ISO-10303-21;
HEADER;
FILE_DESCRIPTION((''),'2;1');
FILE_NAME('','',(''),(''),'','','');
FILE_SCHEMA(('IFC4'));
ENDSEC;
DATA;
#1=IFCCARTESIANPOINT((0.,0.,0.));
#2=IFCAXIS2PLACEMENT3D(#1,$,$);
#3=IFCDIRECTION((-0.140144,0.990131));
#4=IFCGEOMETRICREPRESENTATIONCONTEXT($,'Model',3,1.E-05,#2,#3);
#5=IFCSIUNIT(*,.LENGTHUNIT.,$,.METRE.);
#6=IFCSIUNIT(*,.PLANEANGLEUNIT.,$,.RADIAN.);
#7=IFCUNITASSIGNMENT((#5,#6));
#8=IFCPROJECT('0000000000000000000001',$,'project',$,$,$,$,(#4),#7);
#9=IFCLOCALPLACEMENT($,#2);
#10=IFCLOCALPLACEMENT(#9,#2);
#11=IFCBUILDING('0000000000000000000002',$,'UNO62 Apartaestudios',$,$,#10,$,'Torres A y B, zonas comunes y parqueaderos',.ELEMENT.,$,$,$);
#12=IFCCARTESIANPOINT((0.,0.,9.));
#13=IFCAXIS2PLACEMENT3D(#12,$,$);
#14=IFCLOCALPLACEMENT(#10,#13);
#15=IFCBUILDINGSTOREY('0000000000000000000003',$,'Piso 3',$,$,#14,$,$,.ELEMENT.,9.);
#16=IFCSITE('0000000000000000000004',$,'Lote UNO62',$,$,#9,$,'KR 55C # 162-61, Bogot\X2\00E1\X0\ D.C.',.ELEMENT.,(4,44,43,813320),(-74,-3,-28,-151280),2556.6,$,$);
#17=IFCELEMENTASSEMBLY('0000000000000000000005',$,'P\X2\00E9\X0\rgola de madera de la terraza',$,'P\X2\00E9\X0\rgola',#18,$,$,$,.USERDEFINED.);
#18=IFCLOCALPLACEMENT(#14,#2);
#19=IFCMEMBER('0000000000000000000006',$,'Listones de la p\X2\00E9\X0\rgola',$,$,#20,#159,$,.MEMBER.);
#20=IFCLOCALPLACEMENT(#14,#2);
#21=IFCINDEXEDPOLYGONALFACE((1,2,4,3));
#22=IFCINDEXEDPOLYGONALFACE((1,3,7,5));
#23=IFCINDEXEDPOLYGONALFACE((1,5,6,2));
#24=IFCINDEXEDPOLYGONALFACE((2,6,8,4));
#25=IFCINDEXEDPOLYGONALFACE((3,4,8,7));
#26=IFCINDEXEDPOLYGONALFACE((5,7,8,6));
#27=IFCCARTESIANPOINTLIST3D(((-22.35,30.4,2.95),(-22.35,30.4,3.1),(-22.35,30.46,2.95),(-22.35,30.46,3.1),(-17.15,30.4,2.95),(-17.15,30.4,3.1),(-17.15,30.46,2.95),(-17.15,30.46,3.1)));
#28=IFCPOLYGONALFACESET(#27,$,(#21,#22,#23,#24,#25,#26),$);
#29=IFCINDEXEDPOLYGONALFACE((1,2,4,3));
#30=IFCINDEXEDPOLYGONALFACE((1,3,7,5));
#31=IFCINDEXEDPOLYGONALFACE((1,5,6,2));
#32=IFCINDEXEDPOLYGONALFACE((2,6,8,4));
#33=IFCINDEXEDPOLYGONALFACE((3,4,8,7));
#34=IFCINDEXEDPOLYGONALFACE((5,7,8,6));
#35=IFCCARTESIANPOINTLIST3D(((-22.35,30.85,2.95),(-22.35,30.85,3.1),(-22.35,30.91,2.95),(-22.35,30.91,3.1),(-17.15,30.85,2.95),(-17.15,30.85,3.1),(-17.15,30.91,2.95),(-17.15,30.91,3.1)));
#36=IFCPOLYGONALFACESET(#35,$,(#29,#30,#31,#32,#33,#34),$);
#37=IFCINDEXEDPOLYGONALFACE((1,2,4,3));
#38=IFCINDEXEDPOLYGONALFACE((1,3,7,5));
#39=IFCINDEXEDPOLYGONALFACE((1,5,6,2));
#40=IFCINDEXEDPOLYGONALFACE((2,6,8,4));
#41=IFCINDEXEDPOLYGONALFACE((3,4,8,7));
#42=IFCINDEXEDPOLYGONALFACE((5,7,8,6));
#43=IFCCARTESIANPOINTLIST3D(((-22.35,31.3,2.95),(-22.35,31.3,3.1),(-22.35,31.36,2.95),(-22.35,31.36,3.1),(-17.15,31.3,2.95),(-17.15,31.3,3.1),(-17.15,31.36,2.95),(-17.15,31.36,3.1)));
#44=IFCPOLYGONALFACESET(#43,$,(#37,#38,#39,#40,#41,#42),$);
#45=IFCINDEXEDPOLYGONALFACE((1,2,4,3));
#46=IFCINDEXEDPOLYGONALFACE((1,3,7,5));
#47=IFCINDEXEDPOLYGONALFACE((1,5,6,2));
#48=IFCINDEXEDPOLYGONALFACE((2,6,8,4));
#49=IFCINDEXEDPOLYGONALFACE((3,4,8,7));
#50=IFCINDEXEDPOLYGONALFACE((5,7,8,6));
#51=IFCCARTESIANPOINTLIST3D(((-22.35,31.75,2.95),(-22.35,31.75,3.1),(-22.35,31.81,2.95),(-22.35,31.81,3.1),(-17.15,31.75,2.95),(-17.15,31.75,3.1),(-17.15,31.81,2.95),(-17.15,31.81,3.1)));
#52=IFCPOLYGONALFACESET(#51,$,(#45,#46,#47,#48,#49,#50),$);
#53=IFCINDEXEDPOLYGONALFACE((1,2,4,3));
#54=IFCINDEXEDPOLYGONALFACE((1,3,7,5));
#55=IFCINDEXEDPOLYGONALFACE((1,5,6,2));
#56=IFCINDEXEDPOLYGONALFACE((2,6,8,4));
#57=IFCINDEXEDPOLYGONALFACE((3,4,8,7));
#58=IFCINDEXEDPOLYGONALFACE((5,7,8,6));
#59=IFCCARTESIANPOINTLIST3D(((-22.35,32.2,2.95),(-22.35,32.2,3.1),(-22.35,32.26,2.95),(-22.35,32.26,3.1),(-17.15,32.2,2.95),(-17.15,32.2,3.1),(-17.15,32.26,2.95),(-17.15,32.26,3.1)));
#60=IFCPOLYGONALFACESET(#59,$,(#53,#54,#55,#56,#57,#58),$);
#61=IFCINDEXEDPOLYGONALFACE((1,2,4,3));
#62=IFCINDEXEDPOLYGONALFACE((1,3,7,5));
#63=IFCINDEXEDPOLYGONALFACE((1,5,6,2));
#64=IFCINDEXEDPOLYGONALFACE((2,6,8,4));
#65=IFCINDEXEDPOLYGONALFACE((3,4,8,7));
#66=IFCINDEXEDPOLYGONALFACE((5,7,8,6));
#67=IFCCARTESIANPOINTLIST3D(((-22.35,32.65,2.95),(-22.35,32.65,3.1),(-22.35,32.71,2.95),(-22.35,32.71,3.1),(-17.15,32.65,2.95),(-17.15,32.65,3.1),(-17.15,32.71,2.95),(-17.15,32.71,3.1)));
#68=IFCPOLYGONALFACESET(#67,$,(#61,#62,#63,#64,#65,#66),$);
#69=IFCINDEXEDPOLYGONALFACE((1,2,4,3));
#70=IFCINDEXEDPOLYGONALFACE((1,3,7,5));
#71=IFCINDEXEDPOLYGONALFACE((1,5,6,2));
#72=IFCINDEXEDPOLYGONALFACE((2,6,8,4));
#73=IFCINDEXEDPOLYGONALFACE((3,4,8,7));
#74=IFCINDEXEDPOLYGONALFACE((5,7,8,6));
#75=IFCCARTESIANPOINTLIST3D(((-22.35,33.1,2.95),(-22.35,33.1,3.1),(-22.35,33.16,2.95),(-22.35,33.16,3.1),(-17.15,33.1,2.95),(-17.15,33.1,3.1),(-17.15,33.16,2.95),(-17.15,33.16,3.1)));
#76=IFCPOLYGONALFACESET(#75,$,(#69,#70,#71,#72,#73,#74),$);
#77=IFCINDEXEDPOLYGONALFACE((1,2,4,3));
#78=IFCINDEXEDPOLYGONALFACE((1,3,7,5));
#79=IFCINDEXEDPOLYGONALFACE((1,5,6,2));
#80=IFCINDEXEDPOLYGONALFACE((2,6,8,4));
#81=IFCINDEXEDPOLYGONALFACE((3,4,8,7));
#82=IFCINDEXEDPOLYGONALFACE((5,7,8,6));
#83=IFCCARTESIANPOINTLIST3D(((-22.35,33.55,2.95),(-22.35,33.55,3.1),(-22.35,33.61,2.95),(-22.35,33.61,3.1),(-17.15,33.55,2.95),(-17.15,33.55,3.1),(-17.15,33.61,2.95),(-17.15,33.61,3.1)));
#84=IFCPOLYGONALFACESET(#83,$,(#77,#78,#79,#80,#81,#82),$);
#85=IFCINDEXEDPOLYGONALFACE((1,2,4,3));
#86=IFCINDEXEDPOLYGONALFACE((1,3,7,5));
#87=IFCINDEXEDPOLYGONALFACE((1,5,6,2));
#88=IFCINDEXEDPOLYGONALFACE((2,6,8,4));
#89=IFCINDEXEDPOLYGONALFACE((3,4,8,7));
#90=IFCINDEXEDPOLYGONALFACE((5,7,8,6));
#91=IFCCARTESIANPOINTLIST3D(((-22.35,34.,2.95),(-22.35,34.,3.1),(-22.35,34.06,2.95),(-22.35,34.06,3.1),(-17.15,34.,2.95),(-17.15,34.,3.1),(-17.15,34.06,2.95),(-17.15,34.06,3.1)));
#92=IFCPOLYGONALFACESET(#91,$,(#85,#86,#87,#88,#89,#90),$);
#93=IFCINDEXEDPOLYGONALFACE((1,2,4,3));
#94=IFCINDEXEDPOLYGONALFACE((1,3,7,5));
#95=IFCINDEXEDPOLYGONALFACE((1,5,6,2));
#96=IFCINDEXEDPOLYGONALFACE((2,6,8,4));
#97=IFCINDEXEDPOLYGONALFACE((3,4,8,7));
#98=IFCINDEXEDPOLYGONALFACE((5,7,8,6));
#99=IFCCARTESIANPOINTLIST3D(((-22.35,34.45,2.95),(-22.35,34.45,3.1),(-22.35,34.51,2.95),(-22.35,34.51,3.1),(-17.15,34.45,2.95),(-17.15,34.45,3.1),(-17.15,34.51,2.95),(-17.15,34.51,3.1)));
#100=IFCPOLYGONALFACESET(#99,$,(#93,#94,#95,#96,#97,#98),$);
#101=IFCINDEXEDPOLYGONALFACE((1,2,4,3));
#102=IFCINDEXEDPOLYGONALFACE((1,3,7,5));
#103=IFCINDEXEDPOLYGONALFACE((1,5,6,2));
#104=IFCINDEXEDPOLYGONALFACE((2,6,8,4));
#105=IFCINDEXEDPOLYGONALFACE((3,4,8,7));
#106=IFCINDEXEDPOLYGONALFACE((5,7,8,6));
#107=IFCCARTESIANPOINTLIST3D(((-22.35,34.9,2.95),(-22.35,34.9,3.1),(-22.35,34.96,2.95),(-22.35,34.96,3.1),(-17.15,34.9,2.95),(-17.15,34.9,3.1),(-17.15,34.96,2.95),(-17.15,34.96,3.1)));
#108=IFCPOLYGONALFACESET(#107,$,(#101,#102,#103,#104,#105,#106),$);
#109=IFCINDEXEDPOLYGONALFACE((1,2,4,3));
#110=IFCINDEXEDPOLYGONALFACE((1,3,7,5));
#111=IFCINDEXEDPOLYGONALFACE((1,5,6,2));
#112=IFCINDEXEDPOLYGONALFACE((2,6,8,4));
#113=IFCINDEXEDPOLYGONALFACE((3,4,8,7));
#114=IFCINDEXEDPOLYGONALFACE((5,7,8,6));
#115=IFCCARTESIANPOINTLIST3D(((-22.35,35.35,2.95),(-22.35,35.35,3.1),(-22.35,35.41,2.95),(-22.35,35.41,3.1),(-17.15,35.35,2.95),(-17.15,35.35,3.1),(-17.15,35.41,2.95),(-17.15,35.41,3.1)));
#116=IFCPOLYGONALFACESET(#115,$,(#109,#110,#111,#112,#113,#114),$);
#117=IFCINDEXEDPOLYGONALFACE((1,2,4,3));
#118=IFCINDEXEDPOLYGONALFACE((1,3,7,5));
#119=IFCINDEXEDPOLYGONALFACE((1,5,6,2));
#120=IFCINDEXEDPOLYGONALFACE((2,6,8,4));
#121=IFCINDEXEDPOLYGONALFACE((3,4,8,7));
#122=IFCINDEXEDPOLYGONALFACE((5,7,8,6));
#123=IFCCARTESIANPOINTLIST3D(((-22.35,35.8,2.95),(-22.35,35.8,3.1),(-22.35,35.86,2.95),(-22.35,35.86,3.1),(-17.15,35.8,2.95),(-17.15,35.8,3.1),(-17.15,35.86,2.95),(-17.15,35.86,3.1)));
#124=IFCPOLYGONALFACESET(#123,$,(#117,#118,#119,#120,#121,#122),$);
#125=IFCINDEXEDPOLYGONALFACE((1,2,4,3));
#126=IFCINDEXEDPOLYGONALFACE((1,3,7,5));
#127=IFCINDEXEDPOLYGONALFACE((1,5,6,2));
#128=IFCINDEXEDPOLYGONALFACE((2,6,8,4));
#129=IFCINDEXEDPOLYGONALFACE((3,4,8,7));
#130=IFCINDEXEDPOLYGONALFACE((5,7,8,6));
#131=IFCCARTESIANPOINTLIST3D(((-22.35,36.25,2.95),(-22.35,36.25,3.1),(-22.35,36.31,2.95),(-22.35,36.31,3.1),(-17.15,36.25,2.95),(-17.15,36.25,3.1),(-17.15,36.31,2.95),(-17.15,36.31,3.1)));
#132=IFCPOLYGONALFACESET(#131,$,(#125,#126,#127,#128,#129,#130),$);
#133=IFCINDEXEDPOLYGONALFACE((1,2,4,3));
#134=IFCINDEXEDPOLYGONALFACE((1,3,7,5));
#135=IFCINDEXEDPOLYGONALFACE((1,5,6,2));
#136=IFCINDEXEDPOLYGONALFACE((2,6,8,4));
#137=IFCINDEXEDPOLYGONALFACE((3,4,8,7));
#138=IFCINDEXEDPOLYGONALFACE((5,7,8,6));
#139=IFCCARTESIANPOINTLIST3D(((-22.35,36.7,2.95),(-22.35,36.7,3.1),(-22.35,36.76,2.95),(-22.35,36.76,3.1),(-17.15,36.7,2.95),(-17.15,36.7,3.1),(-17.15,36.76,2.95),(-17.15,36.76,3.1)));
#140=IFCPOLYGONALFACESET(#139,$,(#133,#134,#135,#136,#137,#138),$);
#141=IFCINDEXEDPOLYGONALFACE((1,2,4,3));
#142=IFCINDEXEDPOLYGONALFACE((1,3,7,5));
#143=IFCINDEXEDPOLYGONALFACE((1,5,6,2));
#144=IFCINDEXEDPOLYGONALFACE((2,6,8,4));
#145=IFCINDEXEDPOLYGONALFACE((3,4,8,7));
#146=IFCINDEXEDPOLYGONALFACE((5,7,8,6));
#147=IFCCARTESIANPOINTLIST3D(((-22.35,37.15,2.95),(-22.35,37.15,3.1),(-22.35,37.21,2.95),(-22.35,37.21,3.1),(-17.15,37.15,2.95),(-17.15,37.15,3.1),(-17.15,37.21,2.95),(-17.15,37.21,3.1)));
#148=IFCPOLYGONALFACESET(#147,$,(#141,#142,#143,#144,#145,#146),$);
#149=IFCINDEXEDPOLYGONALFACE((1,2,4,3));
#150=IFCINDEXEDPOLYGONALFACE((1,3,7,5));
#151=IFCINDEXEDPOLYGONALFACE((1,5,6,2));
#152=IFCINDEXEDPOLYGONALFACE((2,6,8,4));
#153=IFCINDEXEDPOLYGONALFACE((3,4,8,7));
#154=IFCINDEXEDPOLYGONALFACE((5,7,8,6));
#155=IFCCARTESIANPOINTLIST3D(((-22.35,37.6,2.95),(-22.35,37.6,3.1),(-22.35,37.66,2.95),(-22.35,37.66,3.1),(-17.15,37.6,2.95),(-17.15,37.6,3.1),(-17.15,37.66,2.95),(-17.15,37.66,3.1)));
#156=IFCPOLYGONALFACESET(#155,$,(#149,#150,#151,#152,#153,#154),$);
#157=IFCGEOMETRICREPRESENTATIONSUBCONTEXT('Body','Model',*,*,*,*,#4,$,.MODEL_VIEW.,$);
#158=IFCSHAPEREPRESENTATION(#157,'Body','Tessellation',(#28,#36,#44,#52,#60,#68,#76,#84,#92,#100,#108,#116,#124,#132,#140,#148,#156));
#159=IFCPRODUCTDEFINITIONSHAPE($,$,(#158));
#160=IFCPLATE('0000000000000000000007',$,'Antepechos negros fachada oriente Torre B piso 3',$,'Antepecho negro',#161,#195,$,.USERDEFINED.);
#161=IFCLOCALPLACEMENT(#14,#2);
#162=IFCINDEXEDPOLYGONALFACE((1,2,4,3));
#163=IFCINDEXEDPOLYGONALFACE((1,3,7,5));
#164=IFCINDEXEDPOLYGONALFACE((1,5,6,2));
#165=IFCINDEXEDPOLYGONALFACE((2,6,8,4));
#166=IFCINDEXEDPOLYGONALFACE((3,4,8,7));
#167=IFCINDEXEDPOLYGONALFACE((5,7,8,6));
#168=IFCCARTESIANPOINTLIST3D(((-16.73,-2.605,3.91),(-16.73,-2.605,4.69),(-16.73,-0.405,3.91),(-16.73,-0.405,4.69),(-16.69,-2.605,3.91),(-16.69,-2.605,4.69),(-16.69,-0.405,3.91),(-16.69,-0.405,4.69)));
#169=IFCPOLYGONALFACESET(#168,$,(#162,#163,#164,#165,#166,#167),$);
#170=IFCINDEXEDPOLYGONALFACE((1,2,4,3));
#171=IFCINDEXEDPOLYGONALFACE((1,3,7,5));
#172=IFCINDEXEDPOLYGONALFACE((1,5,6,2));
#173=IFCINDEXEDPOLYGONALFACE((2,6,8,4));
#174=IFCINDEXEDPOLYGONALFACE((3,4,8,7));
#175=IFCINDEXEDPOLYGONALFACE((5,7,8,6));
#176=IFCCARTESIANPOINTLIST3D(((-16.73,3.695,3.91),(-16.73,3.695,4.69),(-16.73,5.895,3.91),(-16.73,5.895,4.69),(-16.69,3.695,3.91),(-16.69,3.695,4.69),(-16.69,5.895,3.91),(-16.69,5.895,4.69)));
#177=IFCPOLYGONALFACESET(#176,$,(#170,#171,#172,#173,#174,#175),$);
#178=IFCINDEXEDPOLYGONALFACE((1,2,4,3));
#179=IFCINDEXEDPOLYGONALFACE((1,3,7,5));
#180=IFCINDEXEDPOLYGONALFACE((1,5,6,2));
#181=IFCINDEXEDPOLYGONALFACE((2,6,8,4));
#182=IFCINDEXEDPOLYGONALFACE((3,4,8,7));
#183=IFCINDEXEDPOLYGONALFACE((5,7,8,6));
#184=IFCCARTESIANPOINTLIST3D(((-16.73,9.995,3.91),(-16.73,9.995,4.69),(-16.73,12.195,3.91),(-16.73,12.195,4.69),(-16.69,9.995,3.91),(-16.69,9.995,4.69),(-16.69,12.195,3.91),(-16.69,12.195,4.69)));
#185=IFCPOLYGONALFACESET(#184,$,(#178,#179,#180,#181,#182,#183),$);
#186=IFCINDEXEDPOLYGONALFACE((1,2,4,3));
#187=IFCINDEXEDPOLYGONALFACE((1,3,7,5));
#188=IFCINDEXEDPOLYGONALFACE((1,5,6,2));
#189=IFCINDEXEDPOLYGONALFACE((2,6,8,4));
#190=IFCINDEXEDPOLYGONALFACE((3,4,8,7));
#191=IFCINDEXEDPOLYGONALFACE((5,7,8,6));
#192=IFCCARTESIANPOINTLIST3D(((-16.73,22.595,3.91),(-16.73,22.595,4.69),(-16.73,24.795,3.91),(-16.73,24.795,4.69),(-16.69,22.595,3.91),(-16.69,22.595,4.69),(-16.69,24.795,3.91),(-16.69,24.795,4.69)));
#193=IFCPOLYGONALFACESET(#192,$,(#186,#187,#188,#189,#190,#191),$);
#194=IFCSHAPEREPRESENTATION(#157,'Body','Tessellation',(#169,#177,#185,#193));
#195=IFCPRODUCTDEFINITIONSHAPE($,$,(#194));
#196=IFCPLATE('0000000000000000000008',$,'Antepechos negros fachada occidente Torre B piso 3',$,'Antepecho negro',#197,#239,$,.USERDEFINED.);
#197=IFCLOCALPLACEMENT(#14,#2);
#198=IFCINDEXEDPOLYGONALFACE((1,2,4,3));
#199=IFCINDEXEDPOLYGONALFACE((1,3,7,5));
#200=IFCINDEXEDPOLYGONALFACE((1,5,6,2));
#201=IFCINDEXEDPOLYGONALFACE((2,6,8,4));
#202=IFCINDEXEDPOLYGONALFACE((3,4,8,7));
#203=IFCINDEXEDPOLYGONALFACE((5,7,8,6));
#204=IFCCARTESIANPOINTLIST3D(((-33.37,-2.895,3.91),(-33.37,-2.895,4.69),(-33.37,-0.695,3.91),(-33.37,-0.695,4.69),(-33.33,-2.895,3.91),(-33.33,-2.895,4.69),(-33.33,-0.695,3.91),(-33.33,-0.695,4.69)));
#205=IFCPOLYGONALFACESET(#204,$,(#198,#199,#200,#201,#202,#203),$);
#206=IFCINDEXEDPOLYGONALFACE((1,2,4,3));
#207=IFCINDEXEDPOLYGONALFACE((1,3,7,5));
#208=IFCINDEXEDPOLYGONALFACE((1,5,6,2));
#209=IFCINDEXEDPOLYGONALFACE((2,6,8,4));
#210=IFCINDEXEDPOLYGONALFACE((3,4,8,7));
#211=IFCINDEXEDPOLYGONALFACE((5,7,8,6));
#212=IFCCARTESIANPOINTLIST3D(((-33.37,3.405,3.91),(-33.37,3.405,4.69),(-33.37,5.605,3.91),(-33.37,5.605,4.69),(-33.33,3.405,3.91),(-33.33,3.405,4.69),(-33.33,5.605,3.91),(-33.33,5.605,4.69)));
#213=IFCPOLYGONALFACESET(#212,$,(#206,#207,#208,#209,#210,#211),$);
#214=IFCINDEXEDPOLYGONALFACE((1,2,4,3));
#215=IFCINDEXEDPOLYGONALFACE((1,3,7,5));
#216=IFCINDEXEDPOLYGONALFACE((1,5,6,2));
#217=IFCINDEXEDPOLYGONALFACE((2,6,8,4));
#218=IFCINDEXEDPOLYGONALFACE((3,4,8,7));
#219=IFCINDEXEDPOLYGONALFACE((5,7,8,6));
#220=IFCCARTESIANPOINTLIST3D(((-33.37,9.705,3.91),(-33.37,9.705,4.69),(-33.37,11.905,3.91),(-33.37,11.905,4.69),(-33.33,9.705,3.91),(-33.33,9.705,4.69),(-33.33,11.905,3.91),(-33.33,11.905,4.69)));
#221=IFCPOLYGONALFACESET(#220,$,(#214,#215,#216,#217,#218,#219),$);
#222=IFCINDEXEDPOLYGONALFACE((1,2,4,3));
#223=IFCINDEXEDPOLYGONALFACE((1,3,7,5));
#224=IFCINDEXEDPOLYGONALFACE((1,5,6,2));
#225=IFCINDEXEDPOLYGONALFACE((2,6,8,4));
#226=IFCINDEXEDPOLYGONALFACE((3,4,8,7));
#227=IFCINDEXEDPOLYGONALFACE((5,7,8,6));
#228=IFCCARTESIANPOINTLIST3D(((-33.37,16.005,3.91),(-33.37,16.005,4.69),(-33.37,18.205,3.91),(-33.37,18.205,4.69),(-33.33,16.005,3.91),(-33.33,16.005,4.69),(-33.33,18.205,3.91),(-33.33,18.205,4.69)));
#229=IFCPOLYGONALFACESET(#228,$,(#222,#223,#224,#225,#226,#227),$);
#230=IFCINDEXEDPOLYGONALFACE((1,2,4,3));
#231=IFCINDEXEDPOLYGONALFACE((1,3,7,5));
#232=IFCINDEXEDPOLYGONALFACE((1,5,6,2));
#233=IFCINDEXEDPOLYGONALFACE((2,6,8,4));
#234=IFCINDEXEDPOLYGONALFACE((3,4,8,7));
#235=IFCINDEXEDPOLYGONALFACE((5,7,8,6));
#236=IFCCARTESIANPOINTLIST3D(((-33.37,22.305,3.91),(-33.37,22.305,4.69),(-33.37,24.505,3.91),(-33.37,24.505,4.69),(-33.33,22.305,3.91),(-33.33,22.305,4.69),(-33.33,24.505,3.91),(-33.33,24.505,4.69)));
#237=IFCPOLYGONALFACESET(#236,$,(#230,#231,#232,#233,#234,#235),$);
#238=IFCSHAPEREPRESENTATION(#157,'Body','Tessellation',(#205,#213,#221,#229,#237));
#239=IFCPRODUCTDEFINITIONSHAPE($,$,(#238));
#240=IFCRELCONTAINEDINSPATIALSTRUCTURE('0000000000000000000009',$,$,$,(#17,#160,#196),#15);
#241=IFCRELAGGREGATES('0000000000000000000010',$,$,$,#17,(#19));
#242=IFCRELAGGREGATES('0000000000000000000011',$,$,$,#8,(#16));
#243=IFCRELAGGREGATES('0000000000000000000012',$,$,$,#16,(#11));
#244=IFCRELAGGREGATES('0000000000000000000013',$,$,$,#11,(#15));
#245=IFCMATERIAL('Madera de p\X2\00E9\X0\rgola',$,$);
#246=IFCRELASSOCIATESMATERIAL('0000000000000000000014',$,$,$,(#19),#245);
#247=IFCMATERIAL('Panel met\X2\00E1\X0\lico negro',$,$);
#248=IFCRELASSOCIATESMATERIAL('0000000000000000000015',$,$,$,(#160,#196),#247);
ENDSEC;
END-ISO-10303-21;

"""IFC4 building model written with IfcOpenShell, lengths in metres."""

from ifc_helpers import new_model, si_unit, direction, frame, frame_2d, origin, place, context, subcontext, project, spatial, rectangle, extrude, material, element, aggregate, save


model = new_model("IFC4")

# Units and contexts
model_context = context("Model", 3, precision=1e-05, world=origin(), true_north=direction((-0.140144, 0.990131)))
body_context = subcontext(model_context, "Body", "Model", "MODEL_VIEW")
ifc_project = project(units=[si_unit("LENGTHUNIT", "METRE"), si_unit("PLANEANGLEUNIT", "RADIAN")], contexts=[model_context])

# Site, building, storey
site_placement = place(None, origin())
site = spatial("IfcSite", under=ifc_project, at=site_placement, Name="Lote UNO62", LongName="KR 55C # 162-61, Bogotá D.C.", CompositionType="ELEMENT", RefLatitude=(4, 44, 43, 813320), RefLongitude=(-74, -3, -28, -151280), RefElevation=2556.6)
building_placement = place(site_placement, origin())
building = spatial("IfcBuilding", under=site, at=building_placement, Name="UNO62 Apartaestudios", LongName="Torres A y B, zonas comunes y parqueaderos", CompositionType="ELEMENT")
storey_placement = place(building_placement, frame((0.0, 0.0, 9.0)))
storey = spatial("IfcBuildingStorey", under=building, at=storey_placement, Name="Piso 3", CompositionType="ELEMENT", Elevation=9.0)

# Element assembly, member
assembly_placement = place(storey_placement, origin())
assembly = element("IfcElementAssembly", 1, at=assembly_placement, inside=storey, Name="Pérgola de madera de la terraza", ObjectType="Pérgola", PredefinedType="USERDEFINED")
ifc_material_1 = material(Name="Madera de pérgola")
member_placement = place(storey_placement, origin())
member = element("IfcMember", 2, at=member_placement, material=ifc_material_1, Name="Listones de la pérgola", PredefinedType="MEMBER", context=body_context, shape_type="SweptSolid", body=[
    extrude(rectangle(XDim=5.2, YDim=0.06, at=frame_2d((-19.75, 30.43))), frame((0.0, 0.0, 2.95)), (0.0, 0.0, 1.0), 0.15),
    extrude(rectangle(XDim=5.2, YDim=0.06, at=frame_2d((-19.75, 30.88))), frame((0.0, 0.0, 2.95)), (0.0, 0.0, 1.0), 0.15),
    extrude(rectangle(XDim=5.2, YDim=0.06, at=frame_2d((-19.75, 31.33))), frame((0.0, 0.0, 2.95)), (0.0, 0.0, 1.0), 0.15),
    extrude(rectangle(XDim=5.2, YDim=0.06, at=frame_2d((-19.75, 31.78))), frame((0.0, 0.0, 2.95)), (0.0, 0.0, 1.0), 0.15),
    extrude(rectangle(XDim=5.2, YDim=0.06, at=frame_2d((-19.75, 32.23))), frame((0.0, 0.0, 2.95)), (0.0, 0.0, 1.0), 0.15),
    extrude(rectangle(XDim=5.2, YDim=0.06, at=frame_2d((-19.75, 32.68))), frame((0.0, 0.0, 2.95)), (0.0, 0.0, 1.0), 0.15),
    extrude(rectangle(XDim=5.2, YDim=0.06, at=frame_2d((-19.75, 33.13))), frame((0.0, 0.0, 2.95)), (0.0, 0.0, 1.0), 0.15),
    extrude(rectangle(XDim=5.2, YDim=0.06, at=frame_2d((-19.75, 33.58))), frame((0.0, 0.0, 2.95)), (0.0, 0.0, 1.0), 0.15),
    extrude(rectangle(XDim=5.2, YDim=0.06, at=frame_2d((-19.75, 34.03))), frame((0.0, 0.0, 2.95)), (0.0, 0.0, 1.0), 0.15),
    extrude(rectangle(XDim=5.2, YDim=0.06, at=frame_2d((-19.75, 34.48))), frame((0.0, 0.0, 2.95)), (0.0, 0.0, 1.0), 0.15),
    extrude(rectangle(XDim=5.2, YDim=0.06, at=frame_2d((-19.75, 34.93))), frame((0.0, 0.0, 2.95)), (0.0, 0.0, 1.0), 0.15),
    extrude(rectangle(XDim=5.2, YDim=0.06, at=frame_2d((-19.75, 35.38))), frame((0.0, 0.0, 2.95)), (0.0, 0.0, 1.0), 0.15),
    extrude(rectangle(XDim=5.2, YDim=0.06, at=frame_2d((-19.75, 35.83))), frame((0.0, 0.0, 2.95)), (0.0, 0.0, 1.0), 0.15),
    extrude(rectangle(XDim=5.2, YDim=0.06, at=frame_2d((-19.75, 36.28))), frame((0.0, 0.0, 2.95)), (0.0, 0.0, 1.0), 0.15),
    extrude(rectangle(XDim=5.2, YDim=0.06, at=frame_2d((-19.75, 36.73))), frame((0.0, 0.0, 2.95)), (0.0, 0.0, 1.0), 0.15),
    extrude(rectangle(XDim=5.2, YDim=0.06, at=frame_2d((-19.75, 37.18))), frame((0.0, 0.0, 2.95)), (0.0, 0.0, 1.0), 0.15),
    extrude(rectangle(XDim=5.2, YDim=0.06, at=frame_2d((-19.75, 37.63))), frame((0.0, 0.0, 2.95)), (0.0, 0.0, 1.0), 0.15),
])
aggregate(assembly, [member])

# Plates
ifc_material_2 = material(Name="Panel metálico negro")
plate_1_placement = place(storey_placement, origin())
element("IfcPlate", 3, at=plate_1_placement, inside=storey, material=ifc_material_2, Name="Antepechos negros fachada oriente Torre B piso 3", ObjectType="Antepecho negro", PredefinedType="USERDEFINED", context=body_context, shape_type="SweptSolid", body=[
    extrude(rectangle(XDim=0.04, YDim=2.2, at=frame_2d((-16.71, -1.505))), frame((0.0, 0.0, 3.91)), (0.0, 0.0, 1.0), 0.78),
    extrude(rectangle(XDim=0.04, YDim=2.2, at=frame_2d((-16.71, 4.795))), frame((0.0, 0.0, 3.91)), (0.0, 0.0, 1.0), 0.78),
    extrude(rectangle(XDim=0.04, YDim=2.2, at=frame_2d((-16.71, 11.095))), frame((0.0, 0.0, 3.91)), (0.0, 0.0, 1.0), 0.78),
    extrude(rectangle(XDim=0.04, YDim=2.2, at=frame_2d((-16.71, 23.695))), frame((0.0, 0.0, 3.91)), (0.0, 0.0, 1.0), 0.78),
])
plate_2_placement = place(storey_placement, origin())
element("IfcPlate", 4, at=plate_2_placement, inside=storey, material=ifc_material_2, Name="Antepechos negros fachada occidente Torre B piso 3", ObjectType="Antepecho negro", PredefinedType="USERDEFINED", context=body_context, shape_type="SweptSolid", body=[
    extrude(rectangle(XDim=0.04, YDim=2.2, at=frame_2d((-33.35, -1.795))), frame((0.0, 0.0, 3.91)), (0.0, 0.0, 1.0), 0.78),
    extrude(rectangle(XDim=0.04, YDim=2.2, at=frame_2d((-33.35, 4.505))), frame((0.0, 0.0, 3.91)), (0.0, 0.0, 1.0), 0.78),
    extrude(rectangle(XDim=0.04, YDim=2.2, at=frame_2d((-33.35, 10.805))), frame((0.0, 0.0, 3.91)), (0.0, 0.0, 1.0), 0.78),
    extrude(rectangle(XDim=0.04, YDim=2.2, at=frame_2d((-33.35, 17.105))), frame((0.0, 0.0, 3.91)), (0.0, 0.0, 1.0), 0.78),
    extrude(rectangle(XDim=0.04, YDim=2.2, at=frame_2d((-33.35, 23.405))), frame((0.0, 0.0, 3.91)), (0.0, 0.0, 1.0), 0.78),
])

save(model, "model.ifc")
